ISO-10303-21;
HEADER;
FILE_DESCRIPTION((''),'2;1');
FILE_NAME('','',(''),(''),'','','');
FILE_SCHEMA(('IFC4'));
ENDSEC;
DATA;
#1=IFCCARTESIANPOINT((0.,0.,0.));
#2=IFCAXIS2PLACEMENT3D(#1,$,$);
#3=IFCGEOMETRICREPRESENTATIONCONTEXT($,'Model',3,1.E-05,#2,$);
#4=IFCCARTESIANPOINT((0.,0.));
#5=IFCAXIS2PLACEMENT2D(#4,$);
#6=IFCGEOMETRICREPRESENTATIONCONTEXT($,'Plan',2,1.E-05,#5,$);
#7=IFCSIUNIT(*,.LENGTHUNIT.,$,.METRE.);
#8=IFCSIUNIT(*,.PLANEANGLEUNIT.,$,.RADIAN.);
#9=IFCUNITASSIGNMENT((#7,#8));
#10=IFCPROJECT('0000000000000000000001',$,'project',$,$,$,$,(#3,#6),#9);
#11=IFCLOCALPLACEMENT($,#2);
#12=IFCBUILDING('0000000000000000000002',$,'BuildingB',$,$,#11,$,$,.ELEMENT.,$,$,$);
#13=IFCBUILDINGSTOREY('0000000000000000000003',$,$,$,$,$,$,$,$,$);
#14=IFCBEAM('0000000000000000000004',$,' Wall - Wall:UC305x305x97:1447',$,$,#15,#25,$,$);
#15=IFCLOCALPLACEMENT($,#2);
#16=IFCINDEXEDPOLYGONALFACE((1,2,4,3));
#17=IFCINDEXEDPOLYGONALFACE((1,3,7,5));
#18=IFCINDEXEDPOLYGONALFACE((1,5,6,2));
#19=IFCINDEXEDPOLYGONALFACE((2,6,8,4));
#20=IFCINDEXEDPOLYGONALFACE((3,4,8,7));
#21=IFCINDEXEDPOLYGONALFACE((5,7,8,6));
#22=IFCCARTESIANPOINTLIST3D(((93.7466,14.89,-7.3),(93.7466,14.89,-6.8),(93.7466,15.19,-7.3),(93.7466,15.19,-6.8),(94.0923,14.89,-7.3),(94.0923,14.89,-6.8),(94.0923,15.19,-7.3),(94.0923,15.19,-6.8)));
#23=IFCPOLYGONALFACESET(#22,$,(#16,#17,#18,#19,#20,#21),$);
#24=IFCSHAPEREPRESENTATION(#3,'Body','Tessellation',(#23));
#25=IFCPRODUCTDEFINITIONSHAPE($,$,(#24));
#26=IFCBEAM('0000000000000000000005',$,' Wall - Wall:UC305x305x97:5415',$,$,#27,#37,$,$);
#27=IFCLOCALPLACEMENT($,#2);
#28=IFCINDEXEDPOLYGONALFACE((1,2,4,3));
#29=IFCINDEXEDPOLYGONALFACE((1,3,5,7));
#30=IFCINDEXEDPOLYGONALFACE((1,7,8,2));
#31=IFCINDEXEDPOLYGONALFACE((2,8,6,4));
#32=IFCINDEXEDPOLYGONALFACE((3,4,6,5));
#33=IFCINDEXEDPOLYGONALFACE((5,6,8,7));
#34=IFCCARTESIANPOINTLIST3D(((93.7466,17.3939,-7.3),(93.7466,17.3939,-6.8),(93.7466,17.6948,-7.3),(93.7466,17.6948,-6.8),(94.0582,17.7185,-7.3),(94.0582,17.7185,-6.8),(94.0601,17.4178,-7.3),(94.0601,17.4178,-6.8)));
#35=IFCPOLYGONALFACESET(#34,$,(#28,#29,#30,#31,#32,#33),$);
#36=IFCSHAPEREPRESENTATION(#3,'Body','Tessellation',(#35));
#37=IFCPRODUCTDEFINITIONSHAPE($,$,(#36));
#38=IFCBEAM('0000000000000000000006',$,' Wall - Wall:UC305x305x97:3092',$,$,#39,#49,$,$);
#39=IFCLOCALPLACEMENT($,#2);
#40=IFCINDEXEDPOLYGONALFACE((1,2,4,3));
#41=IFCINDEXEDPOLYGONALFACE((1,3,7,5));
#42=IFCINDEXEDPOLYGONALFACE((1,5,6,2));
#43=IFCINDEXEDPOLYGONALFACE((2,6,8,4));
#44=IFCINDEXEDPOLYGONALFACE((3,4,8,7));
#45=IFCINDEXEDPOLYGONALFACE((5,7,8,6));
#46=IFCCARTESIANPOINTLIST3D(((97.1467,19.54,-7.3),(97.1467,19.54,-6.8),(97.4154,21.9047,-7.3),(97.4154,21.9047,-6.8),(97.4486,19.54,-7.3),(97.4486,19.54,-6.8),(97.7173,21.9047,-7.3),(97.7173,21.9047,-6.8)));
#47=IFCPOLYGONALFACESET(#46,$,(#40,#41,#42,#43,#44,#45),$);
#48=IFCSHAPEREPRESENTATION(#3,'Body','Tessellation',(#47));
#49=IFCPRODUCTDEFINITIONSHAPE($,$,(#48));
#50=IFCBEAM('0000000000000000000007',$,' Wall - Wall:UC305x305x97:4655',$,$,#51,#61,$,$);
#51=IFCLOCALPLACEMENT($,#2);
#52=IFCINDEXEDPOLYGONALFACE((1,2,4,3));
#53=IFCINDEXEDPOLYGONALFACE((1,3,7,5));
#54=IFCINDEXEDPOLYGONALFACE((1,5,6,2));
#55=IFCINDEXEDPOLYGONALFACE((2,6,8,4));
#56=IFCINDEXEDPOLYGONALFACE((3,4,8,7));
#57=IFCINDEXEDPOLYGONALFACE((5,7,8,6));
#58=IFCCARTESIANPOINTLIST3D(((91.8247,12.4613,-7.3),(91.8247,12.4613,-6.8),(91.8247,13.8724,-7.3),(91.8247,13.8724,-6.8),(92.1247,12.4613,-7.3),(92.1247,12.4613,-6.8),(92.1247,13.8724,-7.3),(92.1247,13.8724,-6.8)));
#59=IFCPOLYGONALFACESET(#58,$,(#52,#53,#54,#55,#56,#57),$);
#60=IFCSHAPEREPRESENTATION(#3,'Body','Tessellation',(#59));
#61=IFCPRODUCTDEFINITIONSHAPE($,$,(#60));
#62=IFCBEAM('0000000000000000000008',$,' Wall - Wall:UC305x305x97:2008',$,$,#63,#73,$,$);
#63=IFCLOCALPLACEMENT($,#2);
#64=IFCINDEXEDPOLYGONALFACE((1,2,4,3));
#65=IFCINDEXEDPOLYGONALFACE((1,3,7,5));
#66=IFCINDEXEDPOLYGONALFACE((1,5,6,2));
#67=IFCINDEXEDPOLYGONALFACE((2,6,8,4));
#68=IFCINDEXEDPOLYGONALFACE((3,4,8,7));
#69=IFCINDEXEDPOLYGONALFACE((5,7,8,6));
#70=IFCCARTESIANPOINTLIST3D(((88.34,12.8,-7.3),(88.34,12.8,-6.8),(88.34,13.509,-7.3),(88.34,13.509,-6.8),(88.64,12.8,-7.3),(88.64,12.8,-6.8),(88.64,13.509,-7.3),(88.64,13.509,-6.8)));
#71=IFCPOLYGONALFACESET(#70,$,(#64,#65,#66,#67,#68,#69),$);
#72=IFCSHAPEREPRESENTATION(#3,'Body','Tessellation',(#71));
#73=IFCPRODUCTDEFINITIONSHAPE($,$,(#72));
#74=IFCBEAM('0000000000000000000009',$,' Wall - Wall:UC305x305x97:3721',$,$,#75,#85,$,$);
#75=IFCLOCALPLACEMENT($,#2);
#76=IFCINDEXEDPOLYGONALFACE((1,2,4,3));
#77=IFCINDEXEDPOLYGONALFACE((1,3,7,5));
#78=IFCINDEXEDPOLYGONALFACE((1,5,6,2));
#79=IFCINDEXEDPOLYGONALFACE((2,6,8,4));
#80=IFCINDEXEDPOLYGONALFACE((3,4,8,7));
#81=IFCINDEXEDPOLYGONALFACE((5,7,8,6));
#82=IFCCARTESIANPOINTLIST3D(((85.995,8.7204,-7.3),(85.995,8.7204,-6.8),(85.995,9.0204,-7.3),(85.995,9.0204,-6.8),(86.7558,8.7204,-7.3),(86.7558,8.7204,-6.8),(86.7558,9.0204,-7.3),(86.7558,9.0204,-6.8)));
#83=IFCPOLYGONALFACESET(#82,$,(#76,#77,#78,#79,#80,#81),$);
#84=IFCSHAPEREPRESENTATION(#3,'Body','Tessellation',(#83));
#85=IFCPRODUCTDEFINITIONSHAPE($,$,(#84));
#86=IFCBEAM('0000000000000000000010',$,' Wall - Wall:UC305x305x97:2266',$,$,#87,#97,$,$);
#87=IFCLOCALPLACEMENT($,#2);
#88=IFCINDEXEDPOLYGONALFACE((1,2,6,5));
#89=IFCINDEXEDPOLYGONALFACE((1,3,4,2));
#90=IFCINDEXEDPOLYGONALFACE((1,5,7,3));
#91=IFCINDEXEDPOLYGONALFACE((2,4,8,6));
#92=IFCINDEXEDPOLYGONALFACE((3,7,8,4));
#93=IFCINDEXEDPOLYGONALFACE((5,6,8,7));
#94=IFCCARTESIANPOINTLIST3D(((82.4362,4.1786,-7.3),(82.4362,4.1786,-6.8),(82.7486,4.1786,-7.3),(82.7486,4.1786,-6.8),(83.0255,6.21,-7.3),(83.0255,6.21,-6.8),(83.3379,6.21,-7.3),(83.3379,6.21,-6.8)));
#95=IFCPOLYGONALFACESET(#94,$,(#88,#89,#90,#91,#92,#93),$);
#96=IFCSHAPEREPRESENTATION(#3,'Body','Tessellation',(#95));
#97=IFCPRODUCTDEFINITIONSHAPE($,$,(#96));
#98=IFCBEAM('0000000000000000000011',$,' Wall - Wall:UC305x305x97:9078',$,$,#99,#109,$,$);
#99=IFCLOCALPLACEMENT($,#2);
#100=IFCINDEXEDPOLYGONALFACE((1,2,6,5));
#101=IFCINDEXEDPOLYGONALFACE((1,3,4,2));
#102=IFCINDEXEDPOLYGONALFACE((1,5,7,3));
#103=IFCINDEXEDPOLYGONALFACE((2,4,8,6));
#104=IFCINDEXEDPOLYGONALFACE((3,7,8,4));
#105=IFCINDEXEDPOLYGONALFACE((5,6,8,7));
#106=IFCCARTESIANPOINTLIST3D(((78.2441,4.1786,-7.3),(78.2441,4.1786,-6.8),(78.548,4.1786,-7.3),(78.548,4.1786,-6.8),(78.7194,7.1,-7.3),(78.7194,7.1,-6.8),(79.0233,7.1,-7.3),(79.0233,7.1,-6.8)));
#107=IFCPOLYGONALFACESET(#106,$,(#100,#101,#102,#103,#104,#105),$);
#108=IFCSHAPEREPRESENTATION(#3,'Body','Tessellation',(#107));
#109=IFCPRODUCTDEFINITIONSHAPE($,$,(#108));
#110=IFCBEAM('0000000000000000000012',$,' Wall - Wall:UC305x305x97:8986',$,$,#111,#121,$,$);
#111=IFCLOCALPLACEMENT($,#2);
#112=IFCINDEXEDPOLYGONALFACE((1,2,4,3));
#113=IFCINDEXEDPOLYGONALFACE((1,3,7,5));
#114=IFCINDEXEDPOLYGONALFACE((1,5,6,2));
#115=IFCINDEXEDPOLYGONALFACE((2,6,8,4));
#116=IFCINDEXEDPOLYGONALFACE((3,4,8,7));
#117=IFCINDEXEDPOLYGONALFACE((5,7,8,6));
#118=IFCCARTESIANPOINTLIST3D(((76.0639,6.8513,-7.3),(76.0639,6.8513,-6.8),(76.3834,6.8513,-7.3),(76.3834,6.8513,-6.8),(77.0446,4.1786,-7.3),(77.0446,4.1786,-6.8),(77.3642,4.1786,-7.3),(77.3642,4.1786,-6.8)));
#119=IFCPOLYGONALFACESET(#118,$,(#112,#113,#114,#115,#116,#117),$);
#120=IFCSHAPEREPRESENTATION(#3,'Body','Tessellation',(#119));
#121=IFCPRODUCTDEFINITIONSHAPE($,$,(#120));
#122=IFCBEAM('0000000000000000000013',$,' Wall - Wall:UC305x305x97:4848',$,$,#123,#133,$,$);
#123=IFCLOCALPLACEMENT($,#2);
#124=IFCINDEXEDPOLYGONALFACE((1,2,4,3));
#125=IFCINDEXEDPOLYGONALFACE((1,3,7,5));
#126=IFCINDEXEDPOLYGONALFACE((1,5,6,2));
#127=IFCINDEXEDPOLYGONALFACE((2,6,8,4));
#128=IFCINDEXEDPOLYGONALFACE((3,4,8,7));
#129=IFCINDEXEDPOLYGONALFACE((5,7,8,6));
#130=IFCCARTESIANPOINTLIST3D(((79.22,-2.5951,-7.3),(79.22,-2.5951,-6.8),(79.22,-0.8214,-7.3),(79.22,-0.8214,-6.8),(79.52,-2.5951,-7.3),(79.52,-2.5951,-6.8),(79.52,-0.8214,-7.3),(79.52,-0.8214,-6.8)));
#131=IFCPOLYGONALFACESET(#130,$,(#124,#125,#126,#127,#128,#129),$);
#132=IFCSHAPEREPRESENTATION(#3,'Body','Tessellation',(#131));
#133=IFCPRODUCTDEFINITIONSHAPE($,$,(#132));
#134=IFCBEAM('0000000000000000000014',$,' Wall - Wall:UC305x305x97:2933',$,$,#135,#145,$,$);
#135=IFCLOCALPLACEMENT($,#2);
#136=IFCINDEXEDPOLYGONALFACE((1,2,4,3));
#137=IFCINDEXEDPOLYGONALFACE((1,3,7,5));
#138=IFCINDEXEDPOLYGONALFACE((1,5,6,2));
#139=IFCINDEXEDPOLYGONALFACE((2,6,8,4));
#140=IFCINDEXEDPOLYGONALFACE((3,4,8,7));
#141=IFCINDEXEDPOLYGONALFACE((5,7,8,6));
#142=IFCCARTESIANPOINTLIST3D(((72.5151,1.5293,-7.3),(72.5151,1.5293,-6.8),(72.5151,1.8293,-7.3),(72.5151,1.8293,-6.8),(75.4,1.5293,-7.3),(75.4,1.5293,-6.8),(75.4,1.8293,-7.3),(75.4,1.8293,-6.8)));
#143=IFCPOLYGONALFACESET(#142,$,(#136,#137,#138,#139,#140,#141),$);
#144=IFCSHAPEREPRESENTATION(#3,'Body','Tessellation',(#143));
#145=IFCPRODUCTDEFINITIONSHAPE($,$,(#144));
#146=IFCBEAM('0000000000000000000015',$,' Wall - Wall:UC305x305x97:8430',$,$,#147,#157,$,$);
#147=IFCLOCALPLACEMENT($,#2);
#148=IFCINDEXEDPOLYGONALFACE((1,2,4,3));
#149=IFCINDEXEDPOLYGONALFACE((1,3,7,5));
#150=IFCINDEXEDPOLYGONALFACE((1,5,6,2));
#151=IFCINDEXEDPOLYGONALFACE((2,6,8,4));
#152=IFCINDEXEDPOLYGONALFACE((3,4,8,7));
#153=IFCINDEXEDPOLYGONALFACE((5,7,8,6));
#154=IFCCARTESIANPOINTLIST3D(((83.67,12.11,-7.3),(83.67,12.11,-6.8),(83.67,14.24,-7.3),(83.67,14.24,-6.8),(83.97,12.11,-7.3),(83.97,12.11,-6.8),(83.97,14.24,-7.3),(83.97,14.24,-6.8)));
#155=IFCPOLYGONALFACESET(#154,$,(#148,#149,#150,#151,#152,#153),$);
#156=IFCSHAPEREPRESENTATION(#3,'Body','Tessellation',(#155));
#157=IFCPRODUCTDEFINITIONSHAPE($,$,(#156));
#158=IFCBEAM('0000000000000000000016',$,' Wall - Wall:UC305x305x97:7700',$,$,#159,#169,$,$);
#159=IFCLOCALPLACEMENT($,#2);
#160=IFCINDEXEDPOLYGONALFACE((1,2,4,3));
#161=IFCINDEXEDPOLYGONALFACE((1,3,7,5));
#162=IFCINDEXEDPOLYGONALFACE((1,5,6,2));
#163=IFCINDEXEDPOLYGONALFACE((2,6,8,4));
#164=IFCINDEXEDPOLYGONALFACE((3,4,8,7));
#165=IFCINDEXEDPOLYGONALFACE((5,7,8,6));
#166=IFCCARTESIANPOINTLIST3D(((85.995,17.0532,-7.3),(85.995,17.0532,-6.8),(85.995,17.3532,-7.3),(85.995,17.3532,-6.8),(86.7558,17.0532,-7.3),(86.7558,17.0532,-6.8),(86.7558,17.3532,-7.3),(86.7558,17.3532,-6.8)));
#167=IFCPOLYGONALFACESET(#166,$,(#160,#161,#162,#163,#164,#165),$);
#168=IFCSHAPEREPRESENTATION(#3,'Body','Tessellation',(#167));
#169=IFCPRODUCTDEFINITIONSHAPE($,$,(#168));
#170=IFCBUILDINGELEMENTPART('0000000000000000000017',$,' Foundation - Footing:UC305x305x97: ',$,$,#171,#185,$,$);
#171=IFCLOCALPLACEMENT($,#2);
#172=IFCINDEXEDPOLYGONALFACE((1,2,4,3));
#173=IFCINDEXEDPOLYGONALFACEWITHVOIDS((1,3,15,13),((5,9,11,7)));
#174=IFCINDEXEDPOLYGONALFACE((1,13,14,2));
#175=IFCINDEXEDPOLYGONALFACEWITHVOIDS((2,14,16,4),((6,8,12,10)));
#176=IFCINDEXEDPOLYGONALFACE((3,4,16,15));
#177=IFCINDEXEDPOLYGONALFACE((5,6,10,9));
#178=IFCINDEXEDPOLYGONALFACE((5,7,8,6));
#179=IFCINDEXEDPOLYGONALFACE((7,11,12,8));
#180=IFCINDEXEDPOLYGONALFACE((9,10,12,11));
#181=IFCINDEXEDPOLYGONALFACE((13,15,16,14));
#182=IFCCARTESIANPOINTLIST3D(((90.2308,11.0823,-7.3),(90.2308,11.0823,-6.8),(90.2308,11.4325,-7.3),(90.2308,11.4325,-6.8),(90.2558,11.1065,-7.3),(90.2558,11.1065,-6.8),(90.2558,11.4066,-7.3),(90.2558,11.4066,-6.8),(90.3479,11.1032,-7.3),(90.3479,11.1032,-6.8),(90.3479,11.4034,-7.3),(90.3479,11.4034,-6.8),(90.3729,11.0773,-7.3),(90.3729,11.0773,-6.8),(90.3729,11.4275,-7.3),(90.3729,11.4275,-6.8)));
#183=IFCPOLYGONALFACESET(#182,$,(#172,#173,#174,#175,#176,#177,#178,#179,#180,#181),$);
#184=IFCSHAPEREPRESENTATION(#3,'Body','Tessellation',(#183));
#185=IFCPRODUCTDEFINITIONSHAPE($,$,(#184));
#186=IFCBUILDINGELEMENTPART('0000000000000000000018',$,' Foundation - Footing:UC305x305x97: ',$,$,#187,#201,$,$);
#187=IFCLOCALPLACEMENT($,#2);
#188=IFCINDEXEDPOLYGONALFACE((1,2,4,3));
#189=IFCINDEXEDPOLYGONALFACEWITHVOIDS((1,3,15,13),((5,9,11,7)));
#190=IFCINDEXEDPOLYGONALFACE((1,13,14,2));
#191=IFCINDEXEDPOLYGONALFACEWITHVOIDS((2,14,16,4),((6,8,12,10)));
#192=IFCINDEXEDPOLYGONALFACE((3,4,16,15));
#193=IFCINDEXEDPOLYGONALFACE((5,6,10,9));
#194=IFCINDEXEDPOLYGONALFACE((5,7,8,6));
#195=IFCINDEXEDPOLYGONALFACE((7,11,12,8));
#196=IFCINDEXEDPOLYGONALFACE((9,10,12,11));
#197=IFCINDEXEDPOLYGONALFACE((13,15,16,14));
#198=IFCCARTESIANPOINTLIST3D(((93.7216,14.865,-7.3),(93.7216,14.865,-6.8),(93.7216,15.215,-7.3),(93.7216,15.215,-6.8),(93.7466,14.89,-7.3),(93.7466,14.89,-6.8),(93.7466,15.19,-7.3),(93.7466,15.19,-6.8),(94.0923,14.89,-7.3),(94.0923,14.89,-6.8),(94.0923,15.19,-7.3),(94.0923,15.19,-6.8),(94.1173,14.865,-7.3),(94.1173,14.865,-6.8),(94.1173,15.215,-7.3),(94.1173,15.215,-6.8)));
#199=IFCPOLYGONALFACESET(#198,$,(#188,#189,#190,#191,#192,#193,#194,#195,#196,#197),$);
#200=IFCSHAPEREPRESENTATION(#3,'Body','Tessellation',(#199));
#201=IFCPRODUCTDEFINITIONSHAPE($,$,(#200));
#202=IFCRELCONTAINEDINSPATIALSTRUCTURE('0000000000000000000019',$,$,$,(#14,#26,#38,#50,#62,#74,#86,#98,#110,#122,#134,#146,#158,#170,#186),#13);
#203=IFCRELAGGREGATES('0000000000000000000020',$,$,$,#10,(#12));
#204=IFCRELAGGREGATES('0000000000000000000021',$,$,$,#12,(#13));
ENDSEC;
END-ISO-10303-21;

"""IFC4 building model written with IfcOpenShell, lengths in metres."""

from ifc_helpers import new_model, si_unit, origin, origin_2d, place, context, project, spatial, polyline, outline, extrude, element, save


model = new_model("IFC4")

# Units and contexts
model_context = context("Model", 3, precision=1e-05, world=origin())
plan_context = context("Plan", 2, precision=1e-05, world=origin_2d())
ifc_project = project(units=[si_unit("LENGTHUNIT", "METRE"), si_unit("PLANEANGLEUNIT", "RADIAN")], contexts=[model_context, plan_context])

# Building, storey
building_placement = place(None, origin())
building = spatial("IfcBuilding", under=ifc_project, at=building_placement, Name="BuildingB", CompositionType="ELEMENT")
storey = spatial("IfcBuildingStorey", under=building)

# Beams
element("IfcBeam", 1, inside=storey, Name=" Wall - Wall:UC305x305x97:1447", context=model_context, shape_type="SweptSolid", body=[
    extrude(outline(polyline([(94.0923, 15.19, -7.3), (93.7466, 15.19, -7.3), (93.7466, 14.89, -7.3), (94.0923, 14.89, -7.3), (94.0923, 15.19, -7.3)])), None, (0.0, 0.0, 1.0), 0.5),
])
element("IfcBeam", 2, inside=storey, Name=" Wall - Wall:UC305x305x97:5415", context=model_context, shape_type="SweptSolid", body=[
    extrude(outline(polyline([(94.0601, 17.4178, -7.3), (93.7466, 17.3939, -7.3), (93.7466, 17.6948, -7.3), (94.0582, 17.7185, -7.3), (94.0601, 17.4178, -7.3)])), None, (0.0, 0.0, 1.0), 0.5),
])
element("IfcBeam", 3, inside=storey, Name=" Wall - Wall:UC305x305x97:3092", context=model_context, shape_type="SweptSolid", body=[
    extrude(outline(polyline([(97.4486, 19.54, -7.3), (97.1467, 19.54, -7.3), (97.4154, 21.9047, -7.3), (97.7173, 21.9047, -7.3), (97.4486, 19.54, -7.3)])), None, (0.0, 0.0, 1.0), 0.5),
])
element("IfcBeam", 4, inside=storey, Name=" Wall - Wall:UC305x305x97:4655", context=model_context, shape_type="SweptSolid", body=[
    extrude(outline(polyline([(92.1247, 12.4613, -7.3), (91.8247, 12.4613, -7.3), (91.8247, 13.8724, -7.3), (92.1247, 13.8724, -7.3), (92.1247, 12.4613, -7.3)])), None, (0.0, 0.0, 1.0), 0.5),
])
element("IfcBeam", 5, inside=storey, Name=" Wall - Wall:UC305x305x97:2008", context=model_context, shape_type="SweptSolid", body=[
    extrude(outline(polyline([(88.64, 12.8, -7.3), (88.34, 12.8, -7.3), (88.34, 13.509, -7.3), (88.64, 13.509, -7.3), (88.64, 12.8, -7.3)])), None, (0.0, 0.0, 1.0), 0.5),
])
element("IfcBeam", 6, inside=storey, Name=" Wall - Wall:UC305x305x97:3721", context=model_context, shape_type="SweptSolid", body=[
    extrude(outline(polyline([(86.7558, 8.7204, -7.3), (85.995, 8.7204, -7.3), (85.995, 9.0204, -7.3), (86.7558, 9.0204, -7.3), (86.7558, 8.7204, -7.3)])), None, (0.0, 0.0, 1.0), 0.5),
])
element("IfcBeam", 7, inside=storey, Name=" Wall - Wall:UC305x305x97:2266", context=model_context, shape_type="SweptSolid", body=[
    extrude(outline(polyline([(82.7486, 4.1786, -7.3), (82.4362, 4.1786, -7.3), (83.0255, 6.21, -7.3), (83.3379, 6.21, -7.3), (82.7486, 4.1786, -7.3)])), None, (0.0, 0.0, 1.0), 0.5),
])
element("IfcBeam", 8, inside=storey, Name=" Wall - Wall:UC305x305x97:9078", context=model_context, shape_type="SweptSolid", body=[
    extrude(outline(polyline([(78.548, 4.1786, -7.3), (78.2441, 4.1786, -7.3), (78.7194, 7.1, -7.3), (79.0233, 7.1, -7.3), (78.548, 4.1786, -7.3)])), None, (0.0, 0.0, 1.0), 0.5),
])
element("IfcBeam", 9, inside=storey, Name=" Wall - Wall:UC305x305x97:8986", context=model_context, shape_type="SweptSolid", body=[
    extrude(outline(polyline([(77.3642, 4.1786, -7.3), (77.0446, 4.1786, -7.3), (76.0639, 6.8513, -7.3), (76.3834, 6.8513, -7.3), (77.3642, 4.1786, -7.3)])), None, (0.0, 0.0, 1.0), 0.5),
])
element("IfcBeam", 10, inside=storey, Name=" Wall - Wall:UC305x305x97:4848", context=model_context, shape_type="SweptSolid", body=[
    extrude(outline(polyline([(79.52, -2.5951, -7.3), (79.22, -2.5951, -7.3), (79.22, -0.8214, -7.3), (79.52, -0.8214, -7.3), (79.52, -2.5951, -7.3)])), None, (0.0, 0.0, 1.0), 0.5),
])
element("IfcBeam", 11, inside=storey, Name=" Wall - Wall:UC305x305x97:2933", context=model_context, shape_type="SweptSolid", body=[
    extrude(outline(polyline([(75.4, 1.5293, -7.3), (75.4, 1.8293, -7.3), (72.5151, 1.8293, -7.3), (72.5151, 1.5293, -7.3), (75.4, 1.5293, -7.3)])), None, (0.0, 0.0, 1.0), 0.5),
])
element("IfcBeam", 12, inside=storey, Name=" Wall - Wall:UC305x305x97:8430", context=model_context, shape_type="SweptSolid", body=[
    extrude(outline(polyline([(83.97, 12.11, -7.3), (83.67, 12.11, -7.3), (83.67, 14.24, -7.3), (83.97, 14.24, -7.3), (83.97, 12.11, -7.3)])), None, (0.0, 0.0, 1.0), 0.5),
])
element("IfcBeam", 13, inside=storey, Name=" Wall - Wall:UC305x305x97:7700", context=model_context, shape_type="SweptSolid", body=[
    extrude(outline(polyline([(86.7558, 17.0532, -7.3), (86.7558, 17.3532, -7.3), (85.995, 17.3532, -7.3), (85.995, 17.0532, -7.3), (86.7558, 17.0532, -7.3)])), None, (0.0, 0.0, 1.0), 0.5),
])

# Building element parts, openings
building_element_part_1 = element("IfcBuildingElementPart", 14, inside=storey, Name=" Foundation - Footing:UC305x305x97: ", context=model_context, shape_type="SweptSolid", body=[
    extrude(outline(polyline([(90.3729, 11.0773, -7.3), (90.2308, 11.0823, -7.3), (90.2308, 11.4325, -7.3), (90.3729, 11.4275, -7.3), (90.3729, 11.0773, -7.3)])), None, (0.0, 0.0, 1.0), 0.5),
])
element("IfcOpeningElement", 15, inside=storey, cuts=building_element_part_1, context=model_context, shape_type="SweptSolid", body=[
    extrude(outline(polyline([(90.3479, 11.1032, -7.3), (90.2558, 11.1065, -7.3), (90.2558, 11.4066, -7.3), (90.3479, 11.4034, -7.3), (90.3479, 11.1032, -7.3)])), None, (0.0, 0.0, 1.0), 0.5),
])
building_element_part_2 = element("IfcBuildingElementPart", 16, inside=storey, Name=" Foundation - Footing:UC305x305x97: ", context=model_context, shape_type="SweptSolid", body=[
    extrude(outline(polyline([(94.1173, 15.215, -7.3), (93.7216, 15.215, -7.3), (93.7216, 14.865, -7.3), (94.1173, 14.865, -7.3), (94.1173, 15.215, -7.3)])), None, (0.0, 0.0, 1.0), 0.5),
])
element("IfcOpeningElement", 17, inside=storey, cuts=building_element_part_2, context=model_context, shape_type="SweptSolid", body=[
    extrude(outline(polyline([(94.0923, 15.19, -7.3), (93.7466, 15.19, -7.3), (93.7466, 14.89, -7.3), (94.0923, 14.89, -7.3), (94.0923, 15.19, -7.3)])), None, (0.0, 0.0, 1.0), 0.5),
])

save(model, "model.ifc")
